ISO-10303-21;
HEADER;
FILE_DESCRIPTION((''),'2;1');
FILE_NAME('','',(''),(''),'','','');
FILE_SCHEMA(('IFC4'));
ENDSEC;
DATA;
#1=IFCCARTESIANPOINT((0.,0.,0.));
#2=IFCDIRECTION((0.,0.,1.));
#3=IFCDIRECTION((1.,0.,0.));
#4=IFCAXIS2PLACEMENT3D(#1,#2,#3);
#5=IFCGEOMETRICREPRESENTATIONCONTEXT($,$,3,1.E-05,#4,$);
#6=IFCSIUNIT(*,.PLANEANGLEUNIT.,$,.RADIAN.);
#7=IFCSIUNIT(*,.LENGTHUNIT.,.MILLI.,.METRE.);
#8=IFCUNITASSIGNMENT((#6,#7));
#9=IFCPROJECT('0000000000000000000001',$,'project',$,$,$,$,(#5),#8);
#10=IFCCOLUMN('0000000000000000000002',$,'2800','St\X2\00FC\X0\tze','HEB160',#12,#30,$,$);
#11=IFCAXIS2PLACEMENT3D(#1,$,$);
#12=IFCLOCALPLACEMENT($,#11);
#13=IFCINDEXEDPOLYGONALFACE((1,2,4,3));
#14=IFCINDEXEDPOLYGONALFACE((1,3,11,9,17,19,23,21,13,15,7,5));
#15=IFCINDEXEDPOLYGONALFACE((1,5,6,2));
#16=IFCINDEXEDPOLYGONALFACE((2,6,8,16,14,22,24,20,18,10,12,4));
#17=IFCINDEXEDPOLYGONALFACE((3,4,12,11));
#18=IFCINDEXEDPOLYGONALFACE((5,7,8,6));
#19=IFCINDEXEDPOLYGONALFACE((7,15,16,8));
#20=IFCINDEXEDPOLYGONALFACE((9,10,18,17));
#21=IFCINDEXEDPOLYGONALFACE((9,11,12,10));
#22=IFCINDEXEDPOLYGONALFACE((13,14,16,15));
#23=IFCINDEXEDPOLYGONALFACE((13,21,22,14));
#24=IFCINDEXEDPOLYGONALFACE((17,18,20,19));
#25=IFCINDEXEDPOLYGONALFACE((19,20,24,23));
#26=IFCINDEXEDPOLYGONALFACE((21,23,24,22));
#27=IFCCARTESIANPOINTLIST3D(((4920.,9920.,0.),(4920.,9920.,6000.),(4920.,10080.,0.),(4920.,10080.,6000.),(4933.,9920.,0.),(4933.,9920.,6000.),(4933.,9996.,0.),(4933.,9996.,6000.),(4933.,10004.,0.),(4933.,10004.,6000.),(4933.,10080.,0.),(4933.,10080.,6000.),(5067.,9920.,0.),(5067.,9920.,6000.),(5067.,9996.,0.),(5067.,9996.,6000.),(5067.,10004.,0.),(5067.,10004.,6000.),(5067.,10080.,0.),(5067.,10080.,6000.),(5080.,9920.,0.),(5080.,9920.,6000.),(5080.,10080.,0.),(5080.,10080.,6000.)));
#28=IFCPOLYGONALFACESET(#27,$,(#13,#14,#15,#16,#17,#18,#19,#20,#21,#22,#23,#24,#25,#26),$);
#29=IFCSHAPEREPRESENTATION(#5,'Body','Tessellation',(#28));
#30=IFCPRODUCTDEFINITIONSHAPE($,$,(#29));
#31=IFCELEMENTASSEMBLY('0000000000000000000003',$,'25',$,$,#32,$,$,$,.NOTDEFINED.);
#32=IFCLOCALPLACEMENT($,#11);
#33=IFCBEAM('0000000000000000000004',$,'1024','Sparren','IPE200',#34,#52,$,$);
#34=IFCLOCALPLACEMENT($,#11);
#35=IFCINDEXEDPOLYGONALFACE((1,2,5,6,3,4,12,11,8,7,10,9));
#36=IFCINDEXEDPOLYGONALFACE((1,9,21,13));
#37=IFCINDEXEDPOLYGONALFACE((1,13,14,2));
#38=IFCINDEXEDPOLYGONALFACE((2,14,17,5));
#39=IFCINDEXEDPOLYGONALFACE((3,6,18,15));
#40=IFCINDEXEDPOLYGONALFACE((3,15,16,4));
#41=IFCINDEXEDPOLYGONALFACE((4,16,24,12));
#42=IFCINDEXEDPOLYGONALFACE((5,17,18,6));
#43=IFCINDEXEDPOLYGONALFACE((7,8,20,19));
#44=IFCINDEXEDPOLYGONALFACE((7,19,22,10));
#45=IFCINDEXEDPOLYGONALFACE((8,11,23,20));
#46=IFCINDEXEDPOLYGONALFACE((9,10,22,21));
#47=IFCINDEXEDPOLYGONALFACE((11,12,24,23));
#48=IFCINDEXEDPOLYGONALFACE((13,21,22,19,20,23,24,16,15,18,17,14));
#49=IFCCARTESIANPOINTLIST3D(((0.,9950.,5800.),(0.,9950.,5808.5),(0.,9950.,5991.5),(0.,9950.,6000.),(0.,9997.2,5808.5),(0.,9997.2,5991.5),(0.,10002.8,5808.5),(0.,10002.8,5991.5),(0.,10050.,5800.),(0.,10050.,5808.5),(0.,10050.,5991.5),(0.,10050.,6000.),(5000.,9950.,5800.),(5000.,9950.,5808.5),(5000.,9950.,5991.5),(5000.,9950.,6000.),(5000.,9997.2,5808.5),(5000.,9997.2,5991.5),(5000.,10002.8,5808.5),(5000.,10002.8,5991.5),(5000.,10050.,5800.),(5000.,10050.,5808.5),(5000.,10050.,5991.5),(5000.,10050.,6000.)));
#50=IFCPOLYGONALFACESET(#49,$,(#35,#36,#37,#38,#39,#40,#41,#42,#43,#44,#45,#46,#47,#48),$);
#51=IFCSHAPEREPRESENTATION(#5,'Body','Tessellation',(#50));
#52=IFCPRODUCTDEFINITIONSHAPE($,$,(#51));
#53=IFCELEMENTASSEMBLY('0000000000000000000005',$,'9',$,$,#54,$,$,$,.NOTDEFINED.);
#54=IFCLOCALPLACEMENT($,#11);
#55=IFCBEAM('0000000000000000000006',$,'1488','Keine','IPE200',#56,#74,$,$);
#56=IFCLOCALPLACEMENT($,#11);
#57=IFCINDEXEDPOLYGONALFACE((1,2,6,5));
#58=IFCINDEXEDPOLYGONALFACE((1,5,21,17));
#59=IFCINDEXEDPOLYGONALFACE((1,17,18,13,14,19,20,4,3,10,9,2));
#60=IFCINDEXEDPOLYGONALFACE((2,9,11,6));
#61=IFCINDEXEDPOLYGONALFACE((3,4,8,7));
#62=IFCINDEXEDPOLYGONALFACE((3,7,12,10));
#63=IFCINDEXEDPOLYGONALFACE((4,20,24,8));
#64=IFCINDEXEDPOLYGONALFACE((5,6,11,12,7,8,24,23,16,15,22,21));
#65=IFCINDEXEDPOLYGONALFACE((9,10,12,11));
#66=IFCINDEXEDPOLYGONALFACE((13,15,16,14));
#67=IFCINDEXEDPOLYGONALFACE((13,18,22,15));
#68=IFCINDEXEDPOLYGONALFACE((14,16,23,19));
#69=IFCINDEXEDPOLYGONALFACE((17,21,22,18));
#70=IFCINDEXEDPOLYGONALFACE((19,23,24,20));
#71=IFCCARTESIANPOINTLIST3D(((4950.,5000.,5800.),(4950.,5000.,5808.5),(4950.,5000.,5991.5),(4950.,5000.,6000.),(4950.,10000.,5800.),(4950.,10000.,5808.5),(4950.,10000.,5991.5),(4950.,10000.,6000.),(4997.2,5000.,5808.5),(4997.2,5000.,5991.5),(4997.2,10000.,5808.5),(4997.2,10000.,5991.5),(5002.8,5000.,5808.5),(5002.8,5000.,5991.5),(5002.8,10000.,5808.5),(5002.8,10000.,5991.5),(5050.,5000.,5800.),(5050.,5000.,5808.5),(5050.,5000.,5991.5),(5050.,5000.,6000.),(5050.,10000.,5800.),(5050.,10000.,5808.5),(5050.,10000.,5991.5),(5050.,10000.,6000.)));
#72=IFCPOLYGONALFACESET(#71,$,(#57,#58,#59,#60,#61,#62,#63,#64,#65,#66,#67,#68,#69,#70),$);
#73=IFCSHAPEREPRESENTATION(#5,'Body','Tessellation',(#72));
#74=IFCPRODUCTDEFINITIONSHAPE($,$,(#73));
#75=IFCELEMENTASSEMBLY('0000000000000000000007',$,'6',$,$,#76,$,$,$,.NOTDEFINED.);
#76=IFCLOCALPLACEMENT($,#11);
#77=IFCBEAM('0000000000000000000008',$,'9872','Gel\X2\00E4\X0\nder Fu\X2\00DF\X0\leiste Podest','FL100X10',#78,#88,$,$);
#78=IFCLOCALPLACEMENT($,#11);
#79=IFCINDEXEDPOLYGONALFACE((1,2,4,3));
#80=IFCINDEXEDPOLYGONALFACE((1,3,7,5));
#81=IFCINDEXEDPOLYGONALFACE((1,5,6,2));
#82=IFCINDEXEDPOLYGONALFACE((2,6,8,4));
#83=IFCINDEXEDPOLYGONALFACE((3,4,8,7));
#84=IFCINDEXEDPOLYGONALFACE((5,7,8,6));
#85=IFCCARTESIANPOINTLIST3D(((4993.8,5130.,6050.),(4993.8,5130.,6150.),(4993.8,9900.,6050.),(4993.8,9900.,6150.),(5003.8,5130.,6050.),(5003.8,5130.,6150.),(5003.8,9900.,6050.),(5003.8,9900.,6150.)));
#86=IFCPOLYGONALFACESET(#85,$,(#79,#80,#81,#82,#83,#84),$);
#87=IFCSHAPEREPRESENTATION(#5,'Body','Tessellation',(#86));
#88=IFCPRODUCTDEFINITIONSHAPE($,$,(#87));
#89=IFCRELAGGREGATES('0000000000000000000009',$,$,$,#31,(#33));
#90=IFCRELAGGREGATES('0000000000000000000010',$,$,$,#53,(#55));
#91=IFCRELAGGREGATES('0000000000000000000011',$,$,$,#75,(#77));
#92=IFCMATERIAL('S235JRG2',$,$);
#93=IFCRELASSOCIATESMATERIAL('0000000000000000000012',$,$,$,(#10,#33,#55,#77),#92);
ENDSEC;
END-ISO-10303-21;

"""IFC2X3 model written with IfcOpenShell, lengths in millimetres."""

from ifc_helpers import new_model, si_unit, frame, origin_with_axes, place, context, project, polyline, outline, extrude, material, element, aggregate, save


model = new_model("IFC2X3")

# Units and contexts
context_of_model = context(None, 3, precision=1e-05, world=origin_with_axes())
ifc_project = project(units=[si_unit("PLANEANGLEUNIT", "RADIAN"), si_unit("LENGTHUNIT", "METRE", prefix="MILLI")], contexts=[context_of_model])

# Column
ifc_material = material(Name="S235JRG2")
placement_1 = place(None, frame((5000.0, 10000.0, 6000.0), z_axis=(1.0, 0.0, 0.0), x_axis=(0.0, 0.0, -1.0)))
column_placement = place(placement_1, origin_with_axes())
element("IfcColumn", 1, at=column_placement, material=ifc_material, Name="2800", Description="Stütze", ObjectType="HEB160", context=context_of_model, shape_type="SweptSolid", body=[
    extrude(outline(polyline([(80.0, -80.0), (80.0, -67.0), (4.0, -67.0), (4.0, 67.0), (80.0, 67.0), (80.0, 80.0), (-80.0, 80.0), (-80.0, 67.0), (-4.0, 67.0), (-4.0, -67.0), (-80.0, -67.0), (-80.0, -80.0), (80.0, -80.0), (80.0, -80.0)])), frame((0.0, 0.0, 0.0), z_axis=(1.0, 0.0, 0.0), x_axis=(0.0, 1.0, 0.0)), (0.0, 0.0, 1.0), 6000.0),
])

# Element assemblies, beams
assembly_1_placement = place(None, frame((5000.0, 10000.0, 6000.0), z_axis=(0.0, 0.0, 1.0), x_axis=(-1.0, 0.0, 0.0)))
assembly_1 = element("IfcElementAssembly", 2, at=assembly_1_placement, Name="25", PredefinedType="NOTDEFINED")
placement_2 = place(None, frame((5000.0, 10000.0, 5900.0), z_axis=(0.0, 0.0, 1.0), x_axis=(-1.0, 0.0, 0.0)))
beam_1_placement = place(placement_2, origin_with_axes())
beam_1 = element("IfcBeam", 3, at=beam_1_placement, material=ifc_material, Name="1024", Description="Sparren", ObjectType="IPE200", context=context_of_model, shape_type="SweptSolid", body=[
    extrude(outline(polyline([(50.0, -100.0), (50.0, -91.5), (2.8, -91.5), (2.8, 91.5), (50.0, 91.5), (50.0, 100.0), (-50.0, 100.0), (-50.0, 91.5), (-2.8, 91.5), (-2.8, -91.5), (-50.0, -91.5), (-50.0, -100.0), (50.0, -100.0), (50.0, -100.0)])), frame((0.0, 0.0, 0.0), z_axis=(1.0, 0.0, 0.0), x_axis=(0.0, 1.0, 0.0)), (0.0, 0.0, 1.0), 5000.0),
])
aggregate(assembly_1, [beam_1])
assembly_2_placement = place(None, frame((5000.0, 10000.0, 6000.0), z_axis=(0.0, 0.0, 1.0), x_axis=(0.0, -1.0, 0.0)))
assembly_2 = element("IfcElementAssembly", 4, at=assembly_2_placement, Name="9", PredefinedType="NOTDEFINED")
placement_3 = place(None, frame((5000.0, 10000.0, 5900.0), z_axis=(0.0, 0.0, 1.0), x_axis=(0.0, -1.0, 0.0)))
beam_2_placement = place(placement_3, origin_with_axes())
beam_2 = element("IfcBeam", 5, at=beam_2_placement, material=ifc_material, Name="1488", Description="Keine", ObjectType="IPE200", context=context_of_model, shape_type="SweptSolid", body=[
    extrude(outline(polyline([(50.0, -100.0), (50.0, -91.5), (2.8, -91.5), (2.8, 91.5), (50.0, 91.5), (50.0, 100.0), (-50.0, 100.0), (-50.0, 91.5), (-2.8, 91.5), (-2.8, -91.5), (-50.0, -91.5), (-50.0, -100.0), (50.0, -100.0), (50.0, -100.0)])), frame((0.0, 0.0, 0.0), z_axis=(1.0, 0.0, 0.0), x_axis=(0.0, 1.0, 0.0)), (0.0, 0.0, 1.0), 5000.0),
])
aggregate(assembly_2, [beam_2])

# Element assembly, beam
assembly_3_placement = place(None, frame((1.2, 5130.0, 6100.0), z_axis=(0.0, 0.0, 1.0), x_axis=(0.0, 1.0, 0.0)))
assembly_3 = element("IfcElementAssembly", 6, at=assembly_3_placement, Name="6", PredefinedType="NOTDEFINED")
placement_4 = place(None, frame((4998.8, 9900.0, 6100.0), z_axis=(0.0, 0.0, 1.0), x_axis=(0.0, -1.0, 0.0)))
beam_3_placement = place(placement_4, origin_with_axes())
beam_3 = element("IfcBeam", 7, at=beam_3_placement, material=ifc_material, Name="9872", Description="Geländer Fußleiste Podest", ObjectType="FL100X10", context=context_of_model, shape_type="SweptSolid", body=[
    extrude(outline(polyline([(5.0, -50.0), (5.0, 50.0), (-5.0, 50.0), (-5.0, -50.0), (5.0, -50.0), (5.0, -50.0)])), frame((0.0, 0.0, 0.0), z_axis=(1.0, 0.0, 0.0), x_axis=(0.0, 1.0, 0.0)), (0.0, 0.0, 1.0), 4770.0),
])
aggregate(assembly_3, [beam_3])

save(model, "model.ifc")
